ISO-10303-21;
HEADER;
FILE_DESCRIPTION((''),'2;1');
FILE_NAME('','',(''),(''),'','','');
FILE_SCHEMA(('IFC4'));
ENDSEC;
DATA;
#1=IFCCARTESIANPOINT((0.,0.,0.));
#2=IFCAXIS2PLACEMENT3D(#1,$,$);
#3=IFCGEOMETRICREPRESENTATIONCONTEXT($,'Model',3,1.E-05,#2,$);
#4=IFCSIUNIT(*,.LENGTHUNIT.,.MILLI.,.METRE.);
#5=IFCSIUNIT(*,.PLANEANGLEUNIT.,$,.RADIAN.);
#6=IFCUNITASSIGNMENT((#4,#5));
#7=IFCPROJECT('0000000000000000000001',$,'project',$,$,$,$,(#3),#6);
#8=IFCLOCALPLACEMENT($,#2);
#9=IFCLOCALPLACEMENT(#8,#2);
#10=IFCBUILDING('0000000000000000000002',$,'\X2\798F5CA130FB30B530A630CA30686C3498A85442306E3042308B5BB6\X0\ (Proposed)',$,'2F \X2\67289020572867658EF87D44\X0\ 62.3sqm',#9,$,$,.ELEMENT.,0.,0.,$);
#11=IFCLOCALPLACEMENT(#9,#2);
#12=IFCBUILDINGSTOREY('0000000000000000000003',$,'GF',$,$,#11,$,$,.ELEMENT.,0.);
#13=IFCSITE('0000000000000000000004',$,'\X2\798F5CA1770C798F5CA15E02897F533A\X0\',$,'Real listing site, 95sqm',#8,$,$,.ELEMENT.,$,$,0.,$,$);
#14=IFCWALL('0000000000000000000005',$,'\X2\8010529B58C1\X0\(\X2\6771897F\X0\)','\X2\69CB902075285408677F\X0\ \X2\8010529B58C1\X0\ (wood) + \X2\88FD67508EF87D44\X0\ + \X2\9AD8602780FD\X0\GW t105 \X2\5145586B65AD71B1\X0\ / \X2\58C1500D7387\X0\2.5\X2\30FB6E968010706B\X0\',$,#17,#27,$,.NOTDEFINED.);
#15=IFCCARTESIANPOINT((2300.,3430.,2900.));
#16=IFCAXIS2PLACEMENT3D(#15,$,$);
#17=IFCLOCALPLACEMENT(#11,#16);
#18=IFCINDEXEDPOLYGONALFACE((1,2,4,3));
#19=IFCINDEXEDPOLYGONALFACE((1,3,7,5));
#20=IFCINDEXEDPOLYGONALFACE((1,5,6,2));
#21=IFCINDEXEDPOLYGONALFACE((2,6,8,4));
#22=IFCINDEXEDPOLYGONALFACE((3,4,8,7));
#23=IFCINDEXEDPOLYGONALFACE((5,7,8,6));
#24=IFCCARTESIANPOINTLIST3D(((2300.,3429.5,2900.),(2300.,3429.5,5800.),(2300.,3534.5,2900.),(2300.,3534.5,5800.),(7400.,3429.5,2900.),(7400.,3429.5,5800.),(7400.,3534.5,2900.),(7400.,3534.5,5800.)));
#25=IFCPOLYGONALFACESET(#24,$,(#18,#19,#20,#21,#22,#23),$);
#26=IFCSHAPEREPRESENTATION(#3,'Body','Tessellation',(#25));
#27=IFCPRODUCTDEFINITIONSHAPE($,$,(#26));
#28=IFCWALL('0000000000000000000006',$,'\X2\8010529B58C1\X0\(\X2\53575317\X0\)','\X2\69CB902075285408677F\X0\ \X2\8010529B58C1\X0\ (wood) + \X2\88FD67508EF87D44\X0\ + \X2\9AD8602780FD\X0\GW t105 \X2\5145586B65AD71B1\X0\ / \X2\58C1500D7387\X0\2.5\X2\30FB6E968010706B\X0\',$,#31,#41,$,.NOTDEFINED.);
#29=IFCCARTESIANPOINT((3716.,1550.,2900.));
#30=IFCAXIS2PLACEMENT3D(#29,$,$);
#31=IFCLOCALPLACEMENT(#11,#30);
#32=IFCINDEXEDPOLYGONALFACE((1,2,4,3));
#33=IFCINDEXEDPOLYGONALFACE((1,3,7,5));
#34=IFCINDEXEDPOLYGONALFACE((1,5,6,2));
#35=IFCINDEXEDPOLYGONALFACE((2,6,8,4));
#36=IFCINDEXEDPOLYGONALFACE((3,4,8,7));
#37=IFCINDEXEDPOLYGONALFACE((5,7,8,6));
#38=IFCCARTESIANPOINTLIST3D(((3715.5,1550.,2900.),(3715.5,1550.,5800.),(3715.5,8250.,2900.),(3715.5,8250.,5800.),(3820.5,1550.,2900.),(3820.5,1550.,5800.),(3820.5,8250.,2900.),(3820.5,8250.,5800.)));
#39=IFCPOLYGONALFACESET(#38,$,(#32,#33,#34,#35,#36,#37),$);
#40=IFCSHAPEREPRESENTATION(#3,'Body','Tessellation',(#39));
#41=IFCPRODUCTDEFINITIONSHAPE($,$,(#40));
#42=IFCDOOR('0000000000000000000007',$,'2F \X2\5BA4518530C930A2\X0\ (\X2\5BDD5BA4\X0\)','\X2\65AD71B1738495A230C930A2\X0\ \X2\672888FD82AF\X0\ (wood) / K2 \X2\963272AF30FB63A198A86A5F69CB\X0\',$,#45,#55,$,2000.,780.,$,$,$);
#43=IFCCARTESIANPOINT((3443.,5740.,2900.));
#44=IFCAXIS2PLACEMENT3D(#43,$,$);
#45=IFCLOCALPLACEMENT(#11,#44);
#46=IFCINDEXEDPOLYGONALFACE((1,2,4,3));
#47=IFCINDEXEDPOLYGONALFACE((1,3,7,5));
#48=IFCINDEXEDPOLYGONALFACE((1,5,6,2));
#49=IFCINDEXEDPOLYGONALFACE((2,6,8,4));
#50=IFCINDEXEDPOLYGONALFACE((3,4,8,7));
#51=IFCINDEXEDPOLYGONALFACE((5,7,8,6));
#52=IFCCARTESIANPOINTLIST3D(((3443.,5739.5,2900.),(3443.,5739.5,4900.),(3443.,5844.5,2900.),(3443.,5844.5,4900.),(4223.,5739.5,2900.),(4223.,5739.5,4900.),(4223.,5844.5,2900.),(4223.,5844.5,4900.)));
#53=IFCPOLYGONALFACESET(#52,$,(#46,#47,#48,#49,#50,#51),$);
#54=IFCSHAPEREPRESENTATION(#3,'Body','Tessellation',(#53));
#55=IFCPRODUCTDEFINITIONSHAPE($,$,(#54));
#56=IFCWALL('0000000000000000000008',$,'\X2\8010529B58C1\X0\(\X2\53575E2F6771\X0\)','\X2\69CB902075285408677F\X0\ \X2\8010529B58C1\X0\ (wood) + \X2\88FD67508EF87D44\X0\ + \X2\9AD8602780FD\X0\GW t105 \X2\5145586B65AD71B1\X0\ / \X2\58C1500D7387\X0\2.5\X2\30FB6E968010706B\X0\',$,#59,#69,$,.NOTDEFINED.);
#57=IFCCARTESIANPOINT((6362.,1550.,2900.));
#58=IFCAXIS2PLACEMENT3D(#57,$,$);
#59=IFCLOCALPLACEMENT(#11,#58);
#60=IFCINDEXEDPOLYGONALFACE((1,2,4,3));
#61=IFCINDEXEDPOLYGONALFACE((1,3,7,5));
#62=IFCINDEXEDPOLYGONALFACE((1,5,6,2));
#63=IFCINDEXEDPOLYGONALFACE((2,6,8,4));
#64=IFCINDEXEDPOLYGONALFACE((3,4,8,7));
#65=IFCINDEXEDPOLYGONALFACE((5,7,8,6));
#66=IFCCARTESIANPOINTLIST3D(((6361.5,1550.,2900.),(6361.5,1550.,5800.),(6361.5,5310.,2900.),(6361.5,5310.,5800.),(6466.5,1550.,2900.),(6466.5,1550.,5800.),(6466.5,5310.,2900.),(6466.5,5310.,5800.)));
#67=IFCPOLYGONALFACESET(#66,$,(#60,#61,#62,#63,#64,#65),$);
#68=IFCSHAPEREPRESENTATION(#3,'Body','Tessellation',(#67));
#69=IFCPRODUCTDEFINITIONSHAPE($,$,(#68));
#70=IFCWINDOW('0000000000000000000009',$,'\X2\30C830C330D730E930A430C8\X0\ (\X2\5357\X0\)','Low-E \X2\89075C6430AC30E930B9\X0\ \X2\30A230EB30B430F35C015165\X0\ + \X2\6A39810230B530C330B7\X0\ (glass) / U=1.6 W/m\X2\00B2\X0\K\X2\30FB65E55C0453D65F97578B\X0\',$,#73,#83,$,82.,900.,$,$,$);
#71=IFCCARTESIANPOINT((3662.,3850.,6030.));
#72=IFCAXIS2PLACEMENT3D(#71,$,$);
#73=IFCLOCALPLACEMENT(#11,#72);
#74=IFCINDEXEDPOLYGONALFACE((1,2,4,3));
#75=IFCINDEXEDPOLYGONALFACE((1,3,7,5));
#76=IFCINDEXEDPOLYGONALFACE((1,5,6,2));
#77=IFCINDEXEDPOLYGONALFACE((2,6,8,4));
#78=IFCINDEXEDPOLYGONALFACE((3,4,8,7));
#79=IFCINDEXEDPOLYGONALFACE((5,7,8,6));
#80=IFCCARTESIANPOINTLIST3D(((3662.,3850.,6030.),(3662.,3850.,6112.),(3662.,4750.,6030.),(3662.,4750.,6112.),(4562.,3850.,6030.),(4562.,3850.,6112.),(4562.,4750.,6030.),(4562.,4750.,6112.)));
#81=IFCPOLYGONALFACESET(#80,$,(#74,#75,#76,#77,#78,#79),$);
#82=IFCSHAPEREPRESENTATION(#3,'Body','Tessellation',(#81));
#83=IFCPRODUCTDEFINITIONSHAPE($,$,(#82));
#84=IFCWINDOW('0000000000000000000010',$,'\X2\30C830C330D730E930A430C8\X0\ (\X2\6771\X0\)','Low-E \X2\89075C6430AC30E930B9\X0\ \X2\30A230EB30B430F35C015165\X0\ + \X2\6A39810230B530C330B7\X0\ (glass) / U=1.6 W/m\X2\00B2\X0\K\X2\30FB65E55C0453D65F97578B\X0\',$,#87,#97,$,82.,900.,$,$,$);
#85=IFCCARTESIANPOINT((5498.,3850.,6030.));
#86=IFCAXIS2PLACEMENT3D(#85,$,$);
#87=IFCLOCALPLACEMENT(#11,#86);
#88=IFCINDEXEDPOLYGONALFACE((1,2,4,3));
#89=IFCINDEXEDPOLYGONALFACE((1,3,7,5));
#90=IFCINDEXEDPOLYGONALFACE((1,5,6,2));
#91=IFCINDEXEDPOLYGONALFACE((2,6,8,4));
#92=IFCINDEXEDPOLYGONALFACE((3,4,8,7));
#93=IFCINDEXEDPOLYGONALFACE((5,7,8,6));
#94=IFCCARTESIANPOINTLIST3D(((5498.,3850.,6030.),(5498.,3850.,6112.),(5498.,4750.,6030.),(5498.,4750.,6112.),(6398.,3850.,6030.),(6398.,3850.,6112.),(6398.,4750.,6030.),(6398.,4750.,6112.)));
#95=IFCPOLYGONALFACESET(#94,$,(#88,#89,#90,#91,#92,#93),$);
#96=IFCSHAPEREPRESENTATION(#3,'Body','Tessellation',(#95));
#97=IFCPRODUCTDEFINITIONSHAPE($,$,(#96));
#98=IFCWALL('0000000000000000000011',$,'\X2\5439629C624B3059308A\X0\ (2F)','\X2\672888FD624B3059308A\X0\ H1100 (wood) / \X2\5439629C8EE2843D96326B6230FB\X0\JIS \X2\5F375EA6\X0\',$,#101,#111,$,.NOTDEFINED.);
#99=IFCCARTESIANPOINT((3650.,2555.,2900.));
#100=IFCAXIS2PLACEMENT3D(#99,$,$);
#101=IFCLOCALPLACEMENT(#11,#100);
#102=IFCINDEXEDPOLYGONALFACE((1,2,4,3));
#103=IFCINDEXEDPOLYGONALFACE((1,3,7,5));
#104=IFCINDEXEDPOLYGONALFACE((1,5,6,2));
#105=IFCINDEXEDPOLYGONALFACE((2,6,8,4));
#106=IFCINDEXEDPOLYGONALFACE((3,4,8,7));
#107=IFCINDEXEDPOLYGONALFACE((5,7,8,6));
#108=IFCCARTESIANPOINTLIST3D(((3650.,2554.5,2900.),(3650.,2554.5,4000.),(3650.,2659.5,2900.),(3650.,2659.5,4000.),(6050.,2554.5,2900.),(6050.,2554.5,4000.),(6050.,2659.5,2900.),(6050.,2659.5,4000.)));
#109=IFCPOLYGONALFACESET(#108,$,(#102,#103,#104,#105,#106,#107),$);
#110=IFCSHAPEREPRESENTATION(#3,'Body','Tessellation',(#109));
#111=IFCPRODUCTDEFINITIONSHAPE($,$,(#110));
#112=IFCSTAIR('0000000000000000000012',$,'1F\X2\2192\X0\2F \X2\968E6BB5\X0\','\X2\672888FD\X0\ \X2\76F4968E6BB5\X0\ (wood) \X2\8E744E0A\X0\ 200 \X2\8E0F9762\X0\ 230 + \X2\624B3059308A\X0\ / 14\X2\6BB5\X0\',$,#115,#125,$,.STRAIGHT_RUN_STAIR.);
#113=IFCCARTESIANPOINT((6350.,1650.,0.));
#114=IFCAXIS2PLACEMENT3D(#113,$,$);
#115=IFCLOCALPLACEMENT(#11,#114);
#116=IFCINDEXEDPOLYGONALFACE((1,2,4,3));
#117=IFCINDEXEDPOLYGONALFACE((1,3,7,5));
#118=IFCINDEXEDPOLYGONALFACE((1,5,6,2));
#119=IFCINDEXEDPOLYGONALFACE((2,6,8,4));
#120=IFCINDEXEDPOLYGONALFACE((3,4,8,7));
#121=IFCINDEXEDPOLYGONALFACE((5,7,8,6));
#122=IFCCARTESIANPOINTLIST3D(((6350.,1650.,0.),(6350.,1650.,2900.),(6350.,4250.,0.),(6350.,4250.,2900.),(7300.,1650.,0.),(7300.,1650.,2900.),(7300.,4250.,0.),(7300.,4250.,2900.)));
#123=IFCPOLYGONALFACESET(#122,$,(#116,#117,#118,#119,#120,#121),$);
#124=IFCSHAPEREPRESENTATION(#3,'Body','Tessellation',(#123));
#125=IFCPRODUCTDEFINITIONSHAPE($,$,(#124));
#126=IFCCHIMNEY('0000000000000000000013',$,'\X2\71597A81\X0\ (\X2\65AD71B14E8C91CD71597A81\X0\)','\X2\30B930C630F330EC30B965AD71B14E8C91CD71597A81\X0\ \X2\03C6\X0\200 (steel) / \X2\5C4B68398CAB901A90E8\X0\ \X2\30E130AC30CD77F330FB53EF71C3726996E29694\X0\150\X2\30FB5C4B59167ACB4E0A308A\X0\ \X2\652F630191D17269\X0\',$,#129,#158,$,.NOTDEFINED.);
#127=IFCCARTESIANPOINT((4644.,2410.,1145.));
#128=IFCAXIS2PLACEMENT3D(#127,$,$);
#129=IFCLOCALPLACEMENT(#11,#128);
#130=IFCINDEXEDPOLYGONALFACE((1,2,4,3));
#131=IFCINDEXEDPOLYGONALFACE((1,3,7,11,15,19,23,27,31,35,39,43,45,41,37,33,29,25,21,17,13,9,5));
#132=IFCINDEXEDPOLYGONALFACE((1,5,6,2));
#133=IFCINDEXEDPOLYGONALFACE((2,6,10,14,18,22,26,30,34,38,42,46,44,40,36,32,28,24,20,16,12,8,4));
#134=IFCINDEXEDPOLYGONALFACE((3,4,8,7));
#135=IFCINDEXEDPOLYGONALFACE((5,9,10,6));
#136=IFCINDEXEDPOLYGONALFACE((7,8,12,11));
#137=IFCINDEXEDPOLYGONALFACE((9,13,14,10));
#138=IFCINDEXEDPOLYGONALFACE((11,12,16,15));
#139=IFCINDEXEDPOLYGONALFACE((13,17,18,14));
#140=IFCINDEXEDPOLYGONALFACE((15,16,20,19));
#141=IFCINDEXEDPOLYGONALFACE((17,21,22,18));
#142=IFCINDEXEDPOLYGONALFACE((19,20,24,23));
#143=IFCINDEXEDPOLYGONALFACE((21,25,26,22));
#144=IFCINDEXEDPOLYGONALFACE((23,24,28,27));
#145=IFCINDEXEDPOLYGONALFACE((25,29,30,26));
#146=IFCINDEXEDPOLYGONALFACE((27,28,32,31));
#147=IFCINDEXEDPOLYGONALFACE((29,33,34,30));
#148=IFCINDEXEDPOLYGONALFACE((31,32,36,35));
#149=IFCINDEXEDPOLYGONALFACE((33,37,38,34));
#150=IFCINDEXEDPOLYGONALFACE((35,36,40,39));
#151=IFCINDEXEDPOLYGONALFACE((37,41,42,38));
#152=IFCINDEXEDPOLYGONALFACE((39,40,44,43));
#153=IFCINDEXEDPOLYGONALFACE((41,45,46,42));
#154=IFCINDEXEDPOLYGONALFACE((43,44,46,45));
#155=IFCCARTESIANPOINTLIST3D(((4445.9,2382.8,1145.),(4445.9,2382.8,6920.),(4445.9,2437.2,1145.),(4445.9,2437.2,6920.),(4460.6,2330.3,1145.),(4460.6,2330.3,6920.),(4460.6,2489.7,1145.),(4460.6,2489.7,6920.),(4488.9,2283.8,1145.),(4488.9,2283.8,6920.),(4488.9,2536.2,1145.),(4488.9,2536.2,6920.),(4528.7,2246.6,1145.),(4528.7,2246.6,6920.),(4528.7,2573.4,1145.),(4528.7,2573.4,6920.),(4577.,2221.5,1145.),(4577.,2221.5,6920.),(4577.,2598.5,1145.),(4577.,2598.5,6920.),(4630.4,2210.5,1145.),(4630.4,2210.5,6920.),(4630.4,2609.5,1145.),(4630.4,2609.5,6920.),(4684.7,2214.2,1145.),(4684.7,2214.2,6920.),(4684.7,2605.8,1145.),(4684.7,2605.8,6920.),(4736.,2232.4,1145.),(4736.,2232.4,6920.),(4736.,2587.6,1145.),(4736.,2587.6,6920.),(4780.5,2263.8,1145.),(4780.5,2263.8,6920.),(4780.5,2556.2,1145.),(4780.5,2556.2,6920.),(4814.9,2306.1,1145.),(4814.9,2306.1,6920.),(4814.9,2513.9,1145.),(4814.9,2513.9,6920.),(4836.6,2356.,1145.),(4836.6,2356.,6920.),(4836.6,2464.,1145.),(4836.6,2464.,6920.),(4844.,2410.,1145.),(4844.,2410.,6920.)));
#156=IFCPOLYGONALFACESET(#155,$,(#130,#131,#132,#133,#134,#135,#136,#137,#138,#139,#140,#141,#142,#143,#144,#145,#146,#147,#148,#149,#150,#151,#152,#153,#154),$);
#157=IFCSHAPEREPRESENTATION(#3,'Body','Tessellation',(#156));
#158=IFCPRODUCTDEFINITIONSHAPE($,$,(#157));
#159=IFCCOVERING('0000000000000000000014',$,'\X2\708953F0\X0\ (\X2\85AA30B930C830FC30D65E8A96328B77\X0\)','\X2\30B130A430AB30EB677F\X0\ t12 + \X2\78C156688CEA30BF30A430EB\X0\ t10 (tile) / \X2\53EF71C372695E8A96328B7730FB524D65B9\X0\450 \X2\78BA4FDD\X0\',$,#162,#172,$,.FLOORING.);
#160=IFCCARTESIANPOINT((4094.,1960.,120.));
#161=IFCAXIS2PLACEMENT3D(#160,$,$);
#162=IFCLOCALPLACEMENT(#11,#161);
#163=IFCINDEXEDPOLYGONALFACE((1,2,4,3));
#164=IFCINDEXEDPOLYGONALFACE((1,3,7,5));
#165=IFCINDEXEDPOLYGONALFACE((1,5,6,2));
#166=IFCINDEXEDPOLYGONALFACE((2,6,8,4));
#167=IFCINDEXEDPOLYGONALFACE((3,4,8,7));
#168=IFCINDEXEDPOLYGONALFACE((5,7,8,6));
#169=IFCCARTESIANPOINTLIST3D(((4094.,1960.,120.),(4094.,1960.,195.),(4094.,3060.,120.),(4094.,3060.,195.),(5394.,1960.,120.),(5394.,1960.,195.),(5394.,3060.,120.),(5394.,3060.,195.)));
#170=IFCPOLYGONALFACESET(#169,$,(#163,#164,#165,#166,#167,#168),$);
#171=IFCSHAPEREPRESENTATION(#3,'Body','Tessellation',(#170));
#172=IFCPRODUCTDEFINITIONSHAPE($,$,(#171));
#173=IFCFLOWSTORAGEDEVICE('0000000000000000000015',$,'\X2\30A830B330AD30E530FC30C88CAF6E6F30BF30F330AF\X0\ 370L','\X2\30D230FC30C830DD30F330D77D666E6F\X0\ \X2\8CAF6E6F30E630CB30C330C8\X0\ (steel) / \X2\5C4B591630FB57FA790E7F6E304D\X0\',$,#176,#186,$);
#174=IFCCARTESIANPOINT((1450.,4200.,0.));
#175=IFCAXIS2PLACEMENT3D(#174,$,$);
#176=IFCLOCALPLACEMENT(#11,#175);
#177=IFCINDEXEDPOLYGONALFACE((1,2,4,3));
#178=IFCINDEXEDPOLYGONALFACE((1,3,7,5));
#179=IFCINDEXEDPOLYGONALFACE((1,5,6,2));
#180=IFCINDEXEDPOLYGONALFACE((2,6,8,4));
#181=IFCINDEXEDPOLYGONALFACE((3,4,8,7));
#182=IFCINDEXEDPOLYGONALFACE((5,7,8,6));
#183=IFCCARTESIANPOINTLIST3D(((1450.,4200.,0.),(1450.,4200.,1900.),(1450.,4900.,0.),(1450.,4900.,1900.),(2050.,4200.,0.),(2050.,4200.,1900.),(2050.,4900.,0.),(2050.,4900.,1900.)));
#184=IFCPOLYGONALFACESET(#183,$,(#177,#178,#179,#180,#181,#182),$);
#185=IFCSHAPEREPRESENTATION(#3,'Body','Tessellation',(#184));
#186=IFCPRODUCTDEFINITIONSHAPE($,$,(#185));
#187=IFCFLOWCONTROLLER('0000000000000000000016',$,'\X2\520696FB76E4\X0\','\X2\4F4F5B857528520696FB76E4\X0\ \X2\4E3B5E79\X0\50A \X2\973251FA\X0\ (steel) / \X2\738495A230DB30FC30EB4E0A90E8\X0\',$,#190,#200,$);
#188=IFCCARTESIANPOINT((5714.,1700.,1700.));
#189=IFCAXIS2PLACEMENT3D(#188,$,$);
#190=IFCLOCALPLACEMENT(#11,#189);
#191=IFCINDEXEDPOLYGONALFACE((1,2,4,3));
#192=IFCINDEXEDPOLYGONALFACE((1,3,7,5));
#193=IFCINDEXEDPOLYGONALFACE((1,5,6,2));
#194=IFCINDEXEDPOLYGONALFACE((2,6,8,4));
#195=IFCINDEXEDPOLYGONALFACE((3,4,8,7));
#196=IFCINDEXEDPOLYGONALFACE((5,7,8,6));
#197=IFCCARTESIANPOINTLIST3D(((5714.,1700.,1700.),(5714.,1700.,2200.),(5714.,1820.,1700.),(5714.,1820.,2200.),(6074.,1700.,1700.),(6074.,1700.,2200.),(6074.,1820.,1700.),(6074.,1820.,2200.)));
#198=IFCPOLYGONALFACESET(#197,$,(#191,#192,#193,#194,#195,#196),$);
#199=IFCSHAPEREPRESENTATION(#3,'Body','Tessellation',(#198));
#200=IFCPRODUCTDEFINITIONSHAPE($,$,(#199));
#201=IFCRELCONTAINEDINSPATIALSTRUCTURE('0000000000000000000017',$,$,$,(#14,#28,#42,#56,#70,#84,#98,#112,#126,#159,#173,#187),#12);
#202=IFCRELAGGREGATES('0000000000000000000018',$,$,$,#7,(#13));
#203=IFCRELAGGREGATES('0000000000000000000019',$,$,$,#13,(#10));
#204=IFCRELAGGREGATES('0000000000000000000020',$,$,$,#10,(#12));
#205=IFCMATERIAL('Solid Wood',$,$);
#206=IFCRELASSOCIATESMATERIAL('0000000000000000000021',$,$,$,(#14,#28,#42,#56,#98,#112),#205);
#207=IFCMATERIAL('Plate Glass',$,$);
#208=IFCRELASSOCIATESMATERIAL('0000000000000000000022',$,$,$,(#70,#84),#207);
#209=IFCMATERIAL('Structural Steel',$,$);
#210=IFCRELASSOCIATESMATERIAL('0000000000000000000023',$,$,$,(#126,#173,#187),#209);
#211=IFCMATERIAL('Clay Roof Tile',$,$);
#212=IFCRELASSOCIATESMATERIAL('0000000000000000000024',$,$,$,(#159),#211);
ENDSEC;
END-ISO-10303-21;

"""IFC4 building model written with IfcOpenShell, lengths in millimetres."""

from ifc_helpers import new_model, si_unit, frame, frame_2d, origin, origin_2d, place, context, project, spatial, rectangle, circle, extrude, material, element, fill, save


model = new_model("IFC4")

# Units and contexts
model_context = context("Model", 3, precision=1e-05, world=origin())
ifc_project = project(units=[si_unit("LENGTHUNIT", "METRE", prefix="MILLI"), si_unit("PLANEANGLEUNIT", "RADIAN")], contexts=[model_context])

# Site, building, storey
site_placement = place(None, origin())
site = spatial("IfcSite", under=ifc_project, at=site_placement, Name="福岡県福岡市西区", ObjectType="Real listing site, 95sqm", CompositionType="ELEMENT", RefElevation=0.0)
building_placement = place(site_placement, origin())
building = spatial("IfcBuilding", under=site, at=building_placement, Name="福岡・サウナと水風呂のある家 (Proposed)", ObjectType="2F 木造在来軸組 62.3sqm", CompositionType="ELEMENT", ElevationOfRefHeight=0.0, ElevationOfTerrain=0.0)
storey_placement = place(building_placement, origin())
storey = spatial("IfcBuildingStorey", under=building, at=storey_placement, Name="GF", CompositionType="ELEMENT", Elevation=0.0)

# Shared definitions
ifc_material_1 = material(Name="Solid Wood")

# Wall
wall_1_placement = place(storey_placement, frame((2300.0, 3430.0, 2900.0)))
element("IfcWall", 1, at=wall_1_placement, inside=storey, material=ifc_material_1, Name="耐力壁(東西)", Description="構造用合板 耐力壁 (wood) + 製材軸組 + 高性能GW t105 充填断熱 / 壁倍率2.5・準耐火", PredefinedType="NOTDEFINED", context=model_context, shape_type="SweptSolid", body=[
    extrude(rectangle(XDim=5100.0, YDim=105.0, at=frame_2d((2550.0, 52.0))), frame((2300.0, 3430.0, 2900.0)), (0.0, 0.0, 1.0), 2900.0),
])

# Wall, opening, door
wall_2_placement = place(storey_placement, frame((3716.0, 1550.0, 2900.0)))
wall_2 = element("IfcWall", 2, at=wall_2_placement, inside=storey, material=ifc_material_1, Name="耐力壁(南北)", Description="構造用合板 耐力壁 (wood) + 製材軸組 + 高性能GW t105 充填断熱 / 壁倍率2.5・準耐火", PredefinedType="NOTDEFINED", context=model_context, shape_type="SweptSolid", body=[
    extrude(rectangle(XDim=105.0, YDim=6700.0, at=frame_2d((52.0, 3350.0))), frame((3716.0, 1550.0, 2900.0)), (0.0, 0.0, 1.0), 2900.0),
])
opening_placement = place(storey_placement, frame((3443.0, 5740.0, 2900.0)))
opening = element("IfcOpeningElement", 3, at=opening_placement, cuts=wall_2, PredefinedType="NOTDEFINED", context=model_context, shape_type="SweptSolid", body=[
    extrude(rectangle(XDim=780.0, YDim=105.0, at=frame_2d((390.0, 52.0))), frame((3443.0, 5740.0, 2900.0)), (0.0, 0.0, 1.0), 2000.0),
])
door_placement = place(storey_placement, frame((3443.0, 5740.0, 2900.0)))
door = element("IfcDoor", 4, at=door_placement, inside=storey, material=ifc_material_1, Name="2F 室内ドア (寝室)", Description="断熱玄関ドア 木製芯 (wood) / K2 防犯・採風機構", OverallHeight=2000.0, OverallWidth=780.0, context=model_context, shape_type="SweptSolid", body=[
    extrude(rectangle(XDim=780.0, YDim=105.0, at=frame_2d((390.0, 52.0))), frame((3443.0, 5740.0, 2900.0)), (0.0, 0.0, 1.0), 2000.0),
])
fill(opening, door)

# Wall
wall_3_placement = place(storey_placement, frame((6362.0, 1550.0, 2900.0)))
element("IfcWall", 5, at=wall_3_placement, inside=storey, material=ifc_material_1, Name="耐力壁(南帯東)", Description="構造用合板 耐力壁 (wood) + 製材軸組 + 高性能GW t105 充填断熱 / 壁倍率2.5・準耐火", PredefinedType="NOTDEFINED", context=model_context, shape_type="SweptSolid", body=[
    extrude(rectangle(XDim=105.0, YDim=3760.0, at=frame_2d((52.0, 1880.0))), frame((6362.0, 1550.0, 2900.0)), (0.0, 0.0, 1.0), 2900.0),
])

# Windows
ifc_material_2 = material(Name="Plate Glass")
window_1_placement = place(storey_placement, frame((3662.0, 3850.0, 6030.0)))
element("IfcWindow", 6, at=window_1_placement, inside=storey, material=ifc_material_2, Name="トップライト (南)", Description="Low-E 複層ガラス アルゴン封入 + 樹脂サッシ (glass) / U=1.6 W/m²K・日射取得型", OverallHeight=82.0, OverallWidth=900.0, context=model_context, shape_type="SweptSolid", body=[
    extrude(rectangle(XDim=900.0, YDim=900.0, at=frame_2d((450.0, 450.0))), frame((3662.0, 3850.0, 6030.0)), (0.0, 0.0, 1.0), 82.0),
])
window_2_placement = place(storey_placement, frame((5498.0, 3850.0, 6030.0)))
element("IfcWindow", 7, at=window_2_placement, inside=storey, material=ifc_material_2, Name="トップライト (東)", Description="Low-E 複層ガラス アルゴン封入 + 樹脂サッシ (glass) / U=1.6 W/m²K・日射取得型", OverallHeight=82.0, OverallWidth=900.0, context=model_context, shape_type="SweptSolid", body=[
    extrude(rectangle(XDim=900.0, YDim=900.0, at=frame_2d((450.0, 450.0))), frame((5498.0, 3850.0, 6030.0)), (0.0, 0.0, 1.0), 82.0),
])

# Wall
wall_4_placement = place(storey_placement, frame((3650.0, 2555.0, 2900.0)))
element("IfcWall", 8, at=wall_4_placement, inside=storey, material=ifc_material_1, Name="吹抜手すり (2F)", Description="木製手すり H1100 (wood) / 吹抜転落防止・JIS 強度", PredefinedType="NOTDEFINED", context=model_context, shape_type="SweptSolid", body=[
    extrude(rectangle(XDim=2400.0, YDim=105.0, at=frame_2d((1200.0, 52.0))), frame((3650.0, 2555.0, 2900.0)), (0.0, 0.0, 1.0), 1100.0),
])

# Stair
stair_placement = place(storey_placement, frame((6350.0, 1650.0, 0.0)))
element("IfcStair", 9, at=stair_placement, inside=storey, material=ifc_material_1, Name="1F→2F 階段", Description="木製 直階段 (wood) 蹴上 200 踏面 230 + 手すり / 14段", PredefinedType="STRAIGHT_RUN_STAIR", context=model_context, shape_type="SweptSolid", body=[
    extrude(rectangle(XDim=950.0, YDim=2600.0, at=frame_2d((475.0, 1300.0))), frame((6350.0, 1650.0, 0.0)), (0.0, 0.0, 1.0), 2900.0),
])

# Chimney
ifc_material_3 = material(Name="Structural Steel")
chimney_placement = place(storey_placement, frame((4644.0, 2410.0, 1145.0)))
element("IfcChimney", 10, at=chimney_placement, inside=storey, material=ifc_material_3, Name="煙突 (断熱二重煙突)", Description="ステンレス断熱二重煙突 φ200 (steel) / 屋根貫通部 メガネ石・可燃物離隔150・屋外立上り 支持金物", PredefinedType="NOTDEFINED", context=model_context, shape_type="SweptSolid", body=[
    extrude(circle(Radius=200.0, at=origin_2d()), frame((4644.0, 2410.0, 1145.0)), (0.0, 0.0, 1.0), 5775.0),
])

# Covering
ifc_material_4 = material(Name="Clay Roof Tile")
covering_placement = place(storey_placement, frame((4094.0, 1960.0, 120.0)))
element("IfcCovering", 11, at=covering_placement, inside=storey, material=ifc_material_4, Name="炉台 (薪ストーブ床防護)", Description="ケイカル板 t12 + 磁器質タイル t10 (tile) / 可燃物床防護・前方450 確保", PredefinedType="FLOORING", context=model_context, shape_type="SweptSolid", body=[
    extrude(rectangle(XDim=1300.0, YDim=1100.0, at=frame_2d((650.0, 550.0))), frame((4094.0, 1960.0, 120.0)), (0.0, 0.0, 1.0), 75.0),
])

# Flow storage device
flow_storage_device_placement = place(storey_placement, frame((1450.0, 4200.0, 0.0)))
element("IfcFlowStorageDevice", 12, at=flow_storage_device_placement, inside=storey, material=ifc_material_3, Name="エコキュート貯湯タンク 370L", Description="ヒートポンプ給湯 貯湯ユニット (steel) / 屋外・基礎置き", context=model_context, shape_type="SweptSolid", body=[
    extrude(rectangle(XDim=600.0, YDim=700.0, at=frame_2d((300.0, 350.0))), frame((1450.0, 4200.0, 0.0)), (0.0, 0.0, 1.0), 1900.0),
])

# Flow controller
flow_controller_placement = place(storey_placement, frame((5714.0, 1700.0, 1700.0)))
element("IfcFlowController", 13, at=flow_controller_placement, inside=storey, material=ifc_material_3, Name="分電盤", Description="住宅用分電盤 主幹50A 露出 (steel) / 玄関ホール上部", context=model_context, shape_type="SweptSolid", body=[
    extrude(rectangle(XDim=360.0, YDim=120.0, at=frame_2d((180.0, 60.0))), frame((5714.0, 1700.0, 1700.0)), (0.0, 0.0, 1.0), 500.0),
])

save(model, "model.ifc")
